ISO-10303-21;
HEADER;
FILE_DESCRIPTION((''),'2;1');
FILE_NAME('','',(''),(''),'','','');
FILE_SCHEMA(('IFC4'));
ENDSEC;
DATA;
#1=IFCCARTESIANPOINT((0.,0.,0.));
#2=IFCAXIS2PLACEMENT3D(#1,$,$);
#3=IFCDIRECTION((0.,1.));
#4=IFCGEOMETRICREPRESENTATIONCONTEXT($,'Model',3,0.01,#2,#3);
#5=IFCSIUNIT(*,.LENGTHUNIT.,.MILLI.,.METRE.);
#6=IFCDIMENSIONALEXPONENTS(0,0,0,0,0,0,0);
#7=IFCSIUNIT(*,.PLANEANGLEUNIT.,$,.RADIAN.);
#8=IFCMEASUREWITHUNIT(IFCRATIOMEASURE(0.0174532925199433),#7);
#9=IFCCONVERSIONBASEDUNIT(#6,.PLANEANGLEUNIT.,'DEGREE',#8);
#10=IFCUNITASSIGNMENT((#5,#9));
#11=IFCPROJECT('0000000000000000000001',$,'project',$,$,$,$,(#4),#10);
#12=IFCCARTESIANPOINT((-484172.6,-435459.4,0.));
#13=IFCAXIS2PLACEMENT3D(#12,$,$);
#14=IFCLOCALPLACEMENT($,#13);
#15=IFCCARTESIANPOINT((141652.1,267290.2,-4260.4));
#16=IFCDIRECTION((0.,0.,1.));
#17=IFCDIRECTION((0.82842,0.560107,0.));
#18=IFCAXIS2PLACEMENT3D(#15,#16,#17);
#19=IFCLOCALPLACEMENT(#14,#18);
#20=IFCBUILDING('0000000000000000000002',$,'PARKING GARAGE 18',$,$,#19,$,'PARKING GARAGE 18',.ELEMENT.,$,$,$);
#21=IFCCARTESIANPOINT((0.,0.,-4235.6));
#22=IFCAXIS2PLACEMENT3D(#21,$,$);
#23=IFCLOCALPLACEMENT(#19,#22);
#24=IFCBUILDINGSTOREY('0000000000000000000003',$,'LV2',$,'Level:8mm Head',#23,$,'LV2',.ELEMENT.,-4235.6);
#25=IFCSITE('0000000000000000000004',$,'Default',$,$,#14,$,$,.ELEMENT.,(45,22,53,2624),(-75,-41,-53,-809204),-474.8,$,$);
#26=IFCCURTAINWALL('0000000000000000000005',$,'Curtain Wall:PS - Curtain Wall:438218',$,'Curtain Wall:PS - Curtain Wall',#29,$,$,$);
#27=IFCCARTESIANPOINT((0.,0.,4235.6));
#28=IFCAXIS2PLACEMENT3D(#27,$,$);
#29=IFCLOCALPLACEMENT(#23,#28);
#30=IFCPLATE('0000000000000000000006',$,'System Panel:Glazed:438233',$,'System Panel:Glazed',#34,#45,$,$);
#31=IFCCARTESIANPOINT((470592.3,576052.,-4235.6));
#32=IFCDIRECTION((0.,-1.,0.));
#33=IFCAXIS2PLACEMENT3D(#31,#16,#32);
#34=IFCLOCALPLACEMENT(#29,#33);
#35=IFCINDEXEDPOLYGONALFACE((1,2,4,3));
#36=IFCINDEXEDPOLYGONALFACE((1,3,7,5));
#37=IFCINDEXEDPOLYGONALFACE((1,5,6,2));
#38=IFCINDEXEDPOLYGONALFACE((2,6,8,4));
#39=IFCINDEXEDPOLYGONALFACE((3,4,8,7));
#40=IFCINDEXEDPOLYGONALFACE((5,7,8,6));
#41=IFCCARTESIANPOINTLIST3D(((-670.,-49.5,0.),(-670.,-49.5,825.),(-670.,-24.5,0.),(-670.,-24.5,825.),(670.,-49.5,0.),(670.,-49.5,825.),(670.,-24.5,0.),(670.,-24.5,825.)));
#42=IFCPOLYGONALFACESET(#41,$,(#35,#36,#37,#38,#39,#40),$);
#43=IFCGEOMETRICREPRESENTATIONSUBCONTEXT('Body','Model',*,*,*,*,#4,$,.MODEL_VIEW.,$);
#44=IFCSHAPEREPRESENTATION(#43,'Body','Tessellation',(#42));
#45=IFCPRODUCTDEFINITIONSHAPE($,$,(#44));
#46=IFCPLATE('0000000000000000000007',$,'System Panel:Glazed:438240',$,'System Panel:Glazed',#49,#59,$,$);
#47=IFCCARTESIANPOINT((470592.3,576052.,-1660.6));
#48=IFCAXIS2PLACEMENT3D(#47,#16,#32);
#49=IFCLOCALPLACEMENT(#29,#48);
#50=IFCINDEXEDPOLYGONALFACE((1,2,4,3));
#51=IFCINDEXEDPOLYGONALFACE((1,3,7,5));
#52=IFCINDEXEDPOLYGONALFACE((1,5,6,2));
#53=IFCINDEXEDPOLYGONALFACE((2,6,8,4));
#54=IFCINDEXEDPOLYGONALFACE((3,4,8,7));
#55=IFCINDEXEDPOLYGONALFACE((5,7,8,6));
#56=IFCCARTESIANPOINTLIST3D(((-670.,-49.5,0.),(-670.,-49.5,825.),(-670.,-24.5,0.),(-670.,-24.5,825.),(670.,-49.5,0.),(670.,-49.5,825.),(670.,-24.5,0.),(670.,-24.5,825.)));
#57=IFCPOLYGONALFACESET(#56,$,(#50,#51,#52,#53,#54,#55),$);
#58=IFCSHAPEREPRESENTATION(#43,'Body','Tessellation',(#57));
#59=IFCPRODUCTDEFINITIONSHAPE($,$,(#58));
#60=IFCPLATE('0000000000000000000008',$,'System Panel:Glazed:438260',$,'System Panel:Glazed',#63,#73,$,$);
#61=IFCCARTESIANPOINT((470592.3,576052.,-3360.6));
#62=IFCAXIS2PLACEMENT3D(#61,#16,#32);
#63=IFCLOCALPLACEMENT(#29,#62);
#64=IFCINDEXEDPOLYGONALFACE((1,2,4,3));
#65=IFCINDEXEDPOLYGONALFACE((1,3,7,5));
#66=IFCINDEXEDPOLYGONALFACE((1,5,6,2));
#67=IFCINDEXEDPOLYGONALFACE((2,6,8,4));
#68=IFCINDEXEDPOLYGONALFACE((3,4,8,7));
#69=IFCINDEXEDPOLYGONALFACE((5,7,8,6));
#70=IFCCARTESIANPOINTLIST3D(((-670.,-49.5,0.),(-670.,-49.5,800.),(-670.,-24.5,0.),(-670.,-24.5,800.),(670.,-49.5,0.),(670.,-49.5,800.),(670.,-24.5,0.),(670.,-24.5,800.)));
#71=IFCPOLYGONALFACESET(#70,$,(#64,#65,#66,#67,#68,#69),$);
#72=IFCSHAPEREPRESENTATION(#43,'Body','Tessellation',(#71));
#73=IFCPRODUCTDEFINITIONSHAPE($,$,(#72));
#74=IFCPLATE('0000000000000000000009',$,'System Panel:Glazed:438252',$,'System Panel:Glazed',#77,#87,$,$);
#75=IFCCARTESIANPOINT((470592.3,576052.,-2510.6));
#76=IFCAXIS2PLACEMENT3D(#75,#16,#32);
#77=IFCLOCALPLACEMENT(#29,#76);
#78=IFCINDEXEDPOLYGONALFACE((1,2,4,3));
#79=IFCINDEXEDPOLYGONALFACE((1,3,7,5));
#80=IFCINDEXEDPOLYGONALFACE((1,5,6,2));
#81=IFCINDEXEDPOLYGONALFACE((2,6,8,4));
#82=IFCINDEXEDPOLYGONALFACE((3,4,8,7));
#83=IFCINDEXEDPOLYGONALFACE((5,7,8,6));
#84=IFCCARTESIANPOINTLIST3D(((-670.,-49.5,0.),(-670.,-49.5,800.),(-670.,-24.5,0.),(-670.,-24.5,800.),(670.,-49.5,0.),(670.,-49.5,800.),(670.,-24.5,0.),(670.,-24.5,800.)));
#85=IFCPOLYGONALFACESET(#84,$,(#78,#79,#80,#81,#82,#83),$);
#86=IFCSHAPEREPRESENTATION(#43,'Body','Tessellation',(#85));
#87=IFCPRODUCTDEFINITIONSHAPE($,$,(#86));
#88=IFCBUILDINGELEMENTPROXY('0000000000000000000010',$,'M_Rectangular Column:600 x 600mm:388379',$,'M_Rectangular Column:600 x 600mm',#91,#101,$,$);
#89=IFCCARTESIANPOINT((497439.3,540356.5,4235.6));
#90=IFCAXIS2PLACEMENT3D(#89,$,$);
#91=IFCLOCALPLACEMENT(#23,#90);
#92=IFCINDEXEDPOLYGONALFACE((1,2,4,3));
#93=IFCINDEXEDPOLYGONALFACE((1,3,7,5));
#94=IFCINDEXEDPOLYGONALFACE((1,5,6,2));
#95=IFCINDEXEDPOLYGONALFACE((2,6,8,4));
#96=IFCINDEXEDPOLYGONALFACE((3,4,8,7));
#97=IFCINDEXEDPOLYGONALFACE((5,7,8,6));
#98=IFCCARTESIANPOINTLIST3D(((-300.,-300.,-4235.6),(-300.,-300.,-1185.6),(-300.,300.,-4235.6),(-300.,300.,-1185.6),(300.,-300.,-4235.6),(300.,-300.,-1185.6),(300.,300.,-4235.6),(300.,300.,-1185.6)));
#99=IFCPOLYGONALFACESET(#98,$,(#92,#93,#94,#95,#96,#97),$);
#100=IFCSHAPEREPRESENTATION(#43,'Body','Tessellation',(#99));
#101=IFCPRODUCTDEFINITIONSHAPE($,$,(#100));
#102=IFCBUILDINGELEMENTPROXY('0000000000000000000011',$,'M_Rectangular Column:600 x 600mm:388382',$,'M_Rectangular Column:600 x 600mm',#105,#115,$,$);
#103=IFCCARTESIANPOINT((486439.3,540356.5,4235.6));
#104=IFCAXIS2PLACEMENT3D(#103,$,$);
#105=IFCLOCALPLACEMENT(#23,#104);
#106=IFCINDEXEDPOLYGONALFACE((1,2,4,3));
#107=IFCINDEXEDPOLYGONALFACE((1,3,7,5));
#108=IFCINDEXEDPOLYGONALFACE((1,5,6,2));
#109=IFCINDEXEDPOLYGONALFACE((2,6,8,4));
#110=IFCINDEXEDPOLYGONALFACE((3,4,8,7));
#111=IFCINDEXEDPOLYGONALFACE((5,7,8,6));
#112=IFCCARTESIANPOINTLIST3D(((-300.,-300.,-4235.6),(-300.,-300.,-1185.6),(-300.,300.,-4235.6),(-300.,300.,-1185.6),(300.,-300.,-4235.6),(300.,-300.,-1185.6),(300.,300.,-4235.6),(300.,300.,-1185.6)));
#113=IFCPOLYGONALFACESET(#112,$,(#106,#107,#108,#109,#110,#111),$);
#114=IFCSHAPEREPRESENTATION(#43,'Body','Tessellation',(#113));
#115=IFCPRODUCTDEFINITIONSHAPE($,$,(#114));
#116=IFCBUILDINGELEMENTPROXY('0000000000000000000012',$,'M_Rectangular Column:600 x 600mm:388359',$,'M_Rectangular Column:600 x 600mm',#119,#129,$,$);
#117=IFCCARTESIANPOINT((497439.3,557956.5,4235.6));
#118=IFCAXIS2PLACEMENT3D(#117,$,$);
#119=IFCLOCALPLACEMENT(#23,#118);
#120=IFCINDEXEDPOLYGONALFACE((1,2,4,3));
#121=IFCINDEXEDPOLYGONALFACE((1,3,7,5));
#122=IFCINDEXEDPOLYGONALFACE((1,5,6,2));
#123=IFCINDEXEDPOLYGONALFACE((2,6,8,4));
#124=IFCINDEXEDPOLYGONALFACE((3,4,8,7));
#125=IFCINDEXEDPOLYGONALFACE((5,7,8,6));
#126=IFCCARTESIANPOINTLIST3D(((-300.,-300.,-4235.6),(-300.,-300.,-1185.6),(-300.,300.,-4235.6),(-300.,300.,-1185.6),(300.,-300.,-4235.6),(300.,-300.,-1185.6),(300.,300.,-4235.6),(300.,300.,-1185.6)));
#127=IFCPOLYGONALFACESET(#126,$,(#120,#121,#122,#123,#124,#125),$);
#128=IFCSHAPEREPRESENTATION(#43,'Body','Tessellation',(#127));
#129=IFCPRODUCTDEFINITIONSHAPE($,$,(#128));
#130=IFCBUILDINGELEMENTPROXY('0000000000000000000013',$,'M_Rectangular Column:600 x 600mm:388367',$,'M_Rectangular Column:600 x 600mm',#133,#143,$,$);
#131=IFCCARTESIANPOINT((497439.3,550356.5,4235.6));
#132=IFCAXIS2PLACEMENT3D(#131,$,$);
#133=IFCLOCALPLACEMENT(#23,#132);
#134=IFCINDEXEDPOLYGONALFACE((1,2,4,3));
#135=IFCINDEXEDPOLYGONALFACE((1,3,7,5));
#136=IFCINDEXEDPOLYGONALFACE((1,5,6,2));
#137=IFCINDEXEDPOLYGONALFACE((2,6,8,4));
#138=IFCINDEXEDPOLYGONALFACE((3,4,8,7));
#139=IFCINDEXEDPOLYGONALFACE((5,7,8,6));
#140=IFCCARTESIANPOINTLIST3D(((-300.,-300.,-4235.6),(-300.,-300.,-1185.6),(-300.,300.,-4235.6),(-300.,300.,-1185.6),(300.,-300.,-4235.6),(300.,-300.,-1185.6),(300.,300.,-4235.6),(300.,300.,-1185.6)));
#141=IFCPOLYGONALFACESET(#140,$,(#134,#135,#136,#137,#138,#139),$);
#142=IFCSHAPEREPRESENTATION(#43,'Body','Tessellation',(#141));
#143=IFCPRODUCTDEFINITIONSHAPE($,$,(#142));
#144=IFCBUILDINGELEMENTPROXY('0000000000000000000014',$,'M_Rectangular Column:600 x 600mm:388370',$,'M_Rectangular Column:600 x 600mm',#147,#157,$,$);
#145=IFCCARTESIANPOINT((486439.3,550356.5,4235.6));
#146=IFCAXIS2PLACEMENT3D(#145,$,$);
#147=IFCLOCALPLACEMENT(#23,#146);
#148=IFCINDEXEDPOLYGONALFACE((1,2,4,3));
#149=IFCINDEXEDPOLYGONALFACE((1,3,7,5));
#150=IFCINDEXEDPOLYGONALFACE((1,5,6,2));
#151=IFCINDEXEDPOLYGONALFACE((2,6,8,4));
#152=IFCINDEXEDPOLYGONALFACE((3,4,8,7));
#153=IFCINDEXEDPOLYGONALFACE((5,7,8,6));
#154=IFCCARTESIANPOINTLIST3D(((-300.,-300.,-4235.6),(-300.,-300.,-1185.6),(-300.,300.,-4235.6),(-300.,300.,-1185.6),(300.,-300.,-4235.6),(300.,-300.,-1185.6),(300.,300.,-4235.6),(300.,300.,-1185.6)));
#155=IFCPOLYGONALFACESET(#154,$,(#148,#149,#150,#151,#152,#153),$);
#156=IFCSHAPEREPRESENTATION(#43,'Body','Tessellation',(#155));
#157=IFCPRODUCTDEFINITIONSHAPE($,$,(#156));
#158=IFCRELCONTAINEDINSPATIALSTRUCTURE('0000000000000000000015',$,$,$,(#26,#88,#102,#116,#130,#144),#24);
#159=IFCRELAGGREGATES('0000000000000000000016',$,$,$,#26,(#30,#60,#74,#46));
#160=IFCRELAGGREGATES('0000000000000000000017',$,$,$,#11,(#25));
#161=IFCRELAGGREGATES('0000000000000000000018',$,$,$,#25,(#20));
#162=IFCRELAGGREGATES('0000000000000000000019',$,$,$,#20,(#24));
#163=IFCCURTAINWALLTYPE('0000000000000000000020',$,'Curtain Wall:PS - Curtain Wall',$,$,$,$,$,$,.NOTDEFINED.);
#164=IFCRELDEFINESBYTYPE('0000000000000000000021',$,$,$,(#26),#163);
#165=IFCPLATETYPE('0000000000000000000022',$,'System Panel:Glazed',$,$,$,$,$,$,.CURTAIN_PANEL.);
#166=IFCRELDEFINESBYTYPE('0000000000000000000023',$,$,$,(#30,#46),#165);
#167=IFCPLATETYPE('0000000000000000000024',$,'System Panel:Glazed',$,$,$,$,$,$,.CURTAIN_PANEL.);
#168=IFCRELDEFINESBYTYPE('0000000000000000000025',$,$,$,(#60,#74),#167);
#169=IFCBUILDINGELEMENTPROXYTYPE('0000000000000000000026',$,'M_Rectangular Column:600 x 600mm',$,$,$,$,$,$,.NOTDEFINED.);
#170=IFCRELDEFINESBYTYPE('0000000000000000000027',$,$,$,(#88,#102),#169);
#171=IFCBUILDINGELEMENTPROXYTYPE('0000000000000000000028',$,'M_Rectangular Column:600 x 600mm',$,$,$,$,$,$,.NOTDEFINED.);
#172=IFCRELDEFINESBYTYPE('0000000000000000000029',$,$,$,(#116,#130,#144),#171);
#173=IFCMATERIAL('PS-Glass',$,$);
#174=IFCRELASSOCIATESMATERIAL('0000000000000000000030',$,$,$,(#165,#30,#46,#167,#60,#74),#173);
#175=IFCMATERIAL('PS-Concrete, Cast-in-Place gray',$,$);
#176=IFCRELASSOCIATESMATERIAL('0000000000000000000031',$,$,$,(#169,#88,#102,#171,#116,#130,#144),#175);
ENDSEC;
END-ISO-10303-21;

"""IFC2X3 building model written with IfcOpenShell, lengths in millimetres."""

from ifc_helpers import new_model, entity, si_unit, converted_unit, direction, frame, origin, origin_2d_with_axis, place, context, subcontext, project, spatial, rectangle, extrude, source, transform, mapped, material, type_object, type_shapes, element, aggregate, save


model = new_model("IFC2X3")

# Units and contexts
model_context = context("Model", 3, precision=0.01, world=origin(), true_north=direction((0.0, 1.0)))
body_context = subcontext(model_context, "Body", "Model", "MODEL_VIEW")
ifc_project = project(units=[si_unit("LENGTHUNIT", "METRE", prefix="MILLI"), converted_unit("PLANEANGLEUNIT", "DEGREE", entity("IfcRatioMeasure", 0.0174532925199433), si_unit("PLANEANGLEUNIT", "RADIAN"), dimensions=[0, 0, 0, 0, 0, 0, 0])], contexts=[model_context])

# Site, building, storey
site_placement = place(None, frame((-484172.6, -435459.4, 0.0)))
site = spatial("IfcSite", under=ifc_project, at=site_placement, Name="Default", CompositionType="ELEMENT", RefLatitude=(45, 22, 53, 2624), RefLongitude=(-75, -41, -53, -809204), RefElevation=-474.8)
building_placement = place(site_placement, frame((141652.1, 267290.2, -4260.4), z_axis=(0.0, 0.0, 1.0), x_axis=(0.82842, 0.560107, 0.0)))
building = spatial("IfcBuilding", under=site, at=building_placement, Name="PARKING GARAGE 18", LongName="PARKING GARAGE 18", CompositionType="ELEMENT")
storey_placement = place(building_placement, frame((0.0, 0.0, -4235.6)))
storey = spatial("IfcBuildingStorey", under=building, at=storey_placement, Name="LV2", ObjectType="Level:8mm Head", LongName="LV2", CompositionType="ELEMENT", Elevation=-4235.6)

# Curtain wall, plates
curtain_wall_type = type_object("IfcCurtainWallType", Name="Curtain Wall:PS - Curtain Wall", PredefinedType="NOTDEFINED")
curtain_wall_placement = place(storey_placement, frame((0.0, 0.0, 4235.6)))
curtain_wall = element("IfcCurtainWall", 1, at=curtain_wall_placement, inside=storey, type_object=curtain_wall_type, Name="Curtain Wall:PS - Curtain Wall:438218", ObjectType="Curtain Wall:PS - Curtain Wall")
ifc_material_1 = material(Name="PS-Glass")
plate_type_1 = type_object("IfcPlateType", Name="System Panel:Glazed", PredefinedType="CURTAIN_PANEL", material=ifc_material_1)
shared_shape_1 = source(origin(), body_context, "Body", "SweptSolid", [
    extrude(rectangle(XDim=25.0, YDim=1340.0, at=origin_2d_with_axis()), frame((0.0, -37.0, 0.0), z_axis=(0.0, 0.0, 1.0), x_axis=(0.0, 1.0, 0.0)), (0.0, 0.0, 1.0), 825.0),
])
type_shapes(plate_type_1, [shared_shape_1])
plate_1_placement = place(curtain_wall_placement, frame((470592.3, 576052.0, -4235.6), z_axis=(0.0, 0.0, 1.0), x_axis=(0.0, -1.0, 0.0)))
plate_1 = element("IfcPlate", 2, at=plate_1_placement, type_object=plate_type_1, material=ifc_material_1, Name="System Panel:Glazed:438233", ObjectType="System Panel:Glazed", context=body_context, shape_type="MappedRepresentation", body=[
    mapped(shared_shape_1, transform((0.0, 0.0, 0.0), scale=1.0)),
])
plate_2_placement = place(curtain_wall_placement, frame((470592.3, 576052.0, -1660.6), z_axis=(0.0, 0.0, 1.0), x_axis=(0.0, -1.0, 0.0)))
plate_2 = element("IfcPlate", 3, at=plate_2_placement, type_object=plate_type_1, material=ifc_material_1, Name="System Panel:Glazed:438240", ObjectType="System Panel:Glazed", context=body_context, shape_type="MappedRepresentation", body=[
    mapped(shared_shape_1, transform((0.0, 0.0, 0.0), scale=1.0)),
])
plate_type_2 = type_object("IfcPlateType", Name="System Panel:Glazed", PredefinedType="CURTAIN_PANEL", material=ifc_material_1)
shared_shape_2 = source(origin(), body_context, "Body", "SweptSolid", [
    extrude(rectangle(XDim=25.0, YDim=1340.0, at=origin_2d_with_axis()), frame((0.0, -37.0, 0.0), z_axis=(0.0, 0.0, 1.0), x_axis=(0.0, 1.0, 0.0)), (0.0, 0.0, 1.0), 800.0),
])
type_shapes(plate_type_2, [shared_shape_2])
plate_3_placement = place(curtain_wall_placement, frame((470592.3, 576052.0, -3360.6), z_axis=(0.0, 0.0, 1.0), x_axis=(0.0, -1.0, 0.0)))
plate_3 = element("IfcPlate", 4, at=plate_3_placement, type_object=plate_type_2, material=ifc_material_1, Name="System Panel:Glazed:438260", ObjectType="System Panel:Glazed", context=body_context, shape_type="MappedRepresentation", body=[
    mapped(shared_shape_2, transform((0.0, 0.0, 0.0), scale=1.0)),
])
plate_4_placement = place(curtain_wall_placement, frame((470592.3, 576052.0, -2510.6), z_axis=(0.0, 0.0, 1.0), x_axis=(0.0, -1.0, 0.0)))
plate_4 = element("IfcPlate", 5, at=plate_4_placement, type_object=plate_type_2, material=ifc_material_1, Name="System Panel:Glazed:438252", ObjectType="System Panel:Glazed", context=body_context, shape_type="MappedRepresentation", body=[
    mapped(shared_shape_2, transform((0.0, 0.0, 0.0), scale=1.0)),
])
aggregate(curtain_wall, [plate_1, plate_3, plate_4, plate_2])

# Building element proxies
ifc_material_2 = material(Name="PS-Concrete, Cast-in-Place gray")
building_element_proxy_type_1 = type_object("IfcBuildingElementProxyType", Name="M_Rectangular Column:600 x 600mm", PredefinedType="NOTDEFINED", material=ifc_material_2)
shared_shape_3 = source(origin(), body_context, "Body", "SweptSolid", [
    extrude(rectangle(XDim=600.0, YDim=600.0, at=origin_2d_with_axis()), frame((0.0, 0.0, -4235.6), z_axis=(0.0, 0.0, 1.0), x_axis=(-1.0, 0.0, 0.0)), (0.0, 0.0, 1.0), 3050.0),
])
type_shapes(building_element_proxy_type_1, [shared_shape_3])
for number, where, name in (
    (6, (497439.3, 540356.5, 4235.6), "M_Rectangular Column:600 x 600mm:388379"),
    (7, (486439.3, 540356.5, 4235.6), "M_Rectangular Column:600 x 600mm:388382"),
):
    element("IfcBuildingElementProxy", number, at=place(storey_placement, frame(where)), inside=storey, type_object=building_element_proxy_type_1, material=ifc_material_2, Name=name, ObjectType="M_Rectangular Column:600 x 600mm", context=body_context, shape_type="MappedRepresentation", body=[
        mapped(shared_shape_3, transform((0.0, 0.0, 0.0), scale=1.0)),
    ])
building_element_proxy_type_2 = type_object("IfcBuildingElementProxyType", Name="M_Rectangular Column:600 x 600mm", PredefinedType="NOTDEFINED", material=ifc_material_2)
shared_shape_4 = source(origin(), body_context, "Body", "SweptSolid", [
    extrude(rectangle(XDim=600.0, YDim=600.0, at=origin_2d_with_axis()), frame((0.0, 0.0, -4235.6), z_axis=(0.0, 0.0, 1.0), x_axis=(0.0, 1.0, 0.0)), (0.0, 0.0, 1.0), 3050.0),
])
type_shapes(building_element_proxy_type_2, [shared_shape_4])
for number, where, name in (
    (8, (497439.3, 557956.5, 4235.6), "M_Rectangular Column:600 x 600mm:388359"),
    (9, (497439.3, 550356.5, 4235.6), "M_Rectangular Column:600 x 600mm:388367"),
    (10, (486439.3, 550356.5, 4235.6), "M_Rectangular Column:600 x 600mm:388370"),
):
    element("IfcBuildingElementProxy", number, at=place(storey_placement, frame(where)), inside=storey, type_object=building_element_proxy_type_2, material=ifc_material_2, Name=name, ObjectType="M_Rectangular Column:600 x 600mm", context=body_context, shape_type="MappedRepresentation", body=[
        mapped(shared_shape_4, transform((0.0, 0.0, 0.0), scale=1.0)),
    ])

save(model, "model.ifc")
